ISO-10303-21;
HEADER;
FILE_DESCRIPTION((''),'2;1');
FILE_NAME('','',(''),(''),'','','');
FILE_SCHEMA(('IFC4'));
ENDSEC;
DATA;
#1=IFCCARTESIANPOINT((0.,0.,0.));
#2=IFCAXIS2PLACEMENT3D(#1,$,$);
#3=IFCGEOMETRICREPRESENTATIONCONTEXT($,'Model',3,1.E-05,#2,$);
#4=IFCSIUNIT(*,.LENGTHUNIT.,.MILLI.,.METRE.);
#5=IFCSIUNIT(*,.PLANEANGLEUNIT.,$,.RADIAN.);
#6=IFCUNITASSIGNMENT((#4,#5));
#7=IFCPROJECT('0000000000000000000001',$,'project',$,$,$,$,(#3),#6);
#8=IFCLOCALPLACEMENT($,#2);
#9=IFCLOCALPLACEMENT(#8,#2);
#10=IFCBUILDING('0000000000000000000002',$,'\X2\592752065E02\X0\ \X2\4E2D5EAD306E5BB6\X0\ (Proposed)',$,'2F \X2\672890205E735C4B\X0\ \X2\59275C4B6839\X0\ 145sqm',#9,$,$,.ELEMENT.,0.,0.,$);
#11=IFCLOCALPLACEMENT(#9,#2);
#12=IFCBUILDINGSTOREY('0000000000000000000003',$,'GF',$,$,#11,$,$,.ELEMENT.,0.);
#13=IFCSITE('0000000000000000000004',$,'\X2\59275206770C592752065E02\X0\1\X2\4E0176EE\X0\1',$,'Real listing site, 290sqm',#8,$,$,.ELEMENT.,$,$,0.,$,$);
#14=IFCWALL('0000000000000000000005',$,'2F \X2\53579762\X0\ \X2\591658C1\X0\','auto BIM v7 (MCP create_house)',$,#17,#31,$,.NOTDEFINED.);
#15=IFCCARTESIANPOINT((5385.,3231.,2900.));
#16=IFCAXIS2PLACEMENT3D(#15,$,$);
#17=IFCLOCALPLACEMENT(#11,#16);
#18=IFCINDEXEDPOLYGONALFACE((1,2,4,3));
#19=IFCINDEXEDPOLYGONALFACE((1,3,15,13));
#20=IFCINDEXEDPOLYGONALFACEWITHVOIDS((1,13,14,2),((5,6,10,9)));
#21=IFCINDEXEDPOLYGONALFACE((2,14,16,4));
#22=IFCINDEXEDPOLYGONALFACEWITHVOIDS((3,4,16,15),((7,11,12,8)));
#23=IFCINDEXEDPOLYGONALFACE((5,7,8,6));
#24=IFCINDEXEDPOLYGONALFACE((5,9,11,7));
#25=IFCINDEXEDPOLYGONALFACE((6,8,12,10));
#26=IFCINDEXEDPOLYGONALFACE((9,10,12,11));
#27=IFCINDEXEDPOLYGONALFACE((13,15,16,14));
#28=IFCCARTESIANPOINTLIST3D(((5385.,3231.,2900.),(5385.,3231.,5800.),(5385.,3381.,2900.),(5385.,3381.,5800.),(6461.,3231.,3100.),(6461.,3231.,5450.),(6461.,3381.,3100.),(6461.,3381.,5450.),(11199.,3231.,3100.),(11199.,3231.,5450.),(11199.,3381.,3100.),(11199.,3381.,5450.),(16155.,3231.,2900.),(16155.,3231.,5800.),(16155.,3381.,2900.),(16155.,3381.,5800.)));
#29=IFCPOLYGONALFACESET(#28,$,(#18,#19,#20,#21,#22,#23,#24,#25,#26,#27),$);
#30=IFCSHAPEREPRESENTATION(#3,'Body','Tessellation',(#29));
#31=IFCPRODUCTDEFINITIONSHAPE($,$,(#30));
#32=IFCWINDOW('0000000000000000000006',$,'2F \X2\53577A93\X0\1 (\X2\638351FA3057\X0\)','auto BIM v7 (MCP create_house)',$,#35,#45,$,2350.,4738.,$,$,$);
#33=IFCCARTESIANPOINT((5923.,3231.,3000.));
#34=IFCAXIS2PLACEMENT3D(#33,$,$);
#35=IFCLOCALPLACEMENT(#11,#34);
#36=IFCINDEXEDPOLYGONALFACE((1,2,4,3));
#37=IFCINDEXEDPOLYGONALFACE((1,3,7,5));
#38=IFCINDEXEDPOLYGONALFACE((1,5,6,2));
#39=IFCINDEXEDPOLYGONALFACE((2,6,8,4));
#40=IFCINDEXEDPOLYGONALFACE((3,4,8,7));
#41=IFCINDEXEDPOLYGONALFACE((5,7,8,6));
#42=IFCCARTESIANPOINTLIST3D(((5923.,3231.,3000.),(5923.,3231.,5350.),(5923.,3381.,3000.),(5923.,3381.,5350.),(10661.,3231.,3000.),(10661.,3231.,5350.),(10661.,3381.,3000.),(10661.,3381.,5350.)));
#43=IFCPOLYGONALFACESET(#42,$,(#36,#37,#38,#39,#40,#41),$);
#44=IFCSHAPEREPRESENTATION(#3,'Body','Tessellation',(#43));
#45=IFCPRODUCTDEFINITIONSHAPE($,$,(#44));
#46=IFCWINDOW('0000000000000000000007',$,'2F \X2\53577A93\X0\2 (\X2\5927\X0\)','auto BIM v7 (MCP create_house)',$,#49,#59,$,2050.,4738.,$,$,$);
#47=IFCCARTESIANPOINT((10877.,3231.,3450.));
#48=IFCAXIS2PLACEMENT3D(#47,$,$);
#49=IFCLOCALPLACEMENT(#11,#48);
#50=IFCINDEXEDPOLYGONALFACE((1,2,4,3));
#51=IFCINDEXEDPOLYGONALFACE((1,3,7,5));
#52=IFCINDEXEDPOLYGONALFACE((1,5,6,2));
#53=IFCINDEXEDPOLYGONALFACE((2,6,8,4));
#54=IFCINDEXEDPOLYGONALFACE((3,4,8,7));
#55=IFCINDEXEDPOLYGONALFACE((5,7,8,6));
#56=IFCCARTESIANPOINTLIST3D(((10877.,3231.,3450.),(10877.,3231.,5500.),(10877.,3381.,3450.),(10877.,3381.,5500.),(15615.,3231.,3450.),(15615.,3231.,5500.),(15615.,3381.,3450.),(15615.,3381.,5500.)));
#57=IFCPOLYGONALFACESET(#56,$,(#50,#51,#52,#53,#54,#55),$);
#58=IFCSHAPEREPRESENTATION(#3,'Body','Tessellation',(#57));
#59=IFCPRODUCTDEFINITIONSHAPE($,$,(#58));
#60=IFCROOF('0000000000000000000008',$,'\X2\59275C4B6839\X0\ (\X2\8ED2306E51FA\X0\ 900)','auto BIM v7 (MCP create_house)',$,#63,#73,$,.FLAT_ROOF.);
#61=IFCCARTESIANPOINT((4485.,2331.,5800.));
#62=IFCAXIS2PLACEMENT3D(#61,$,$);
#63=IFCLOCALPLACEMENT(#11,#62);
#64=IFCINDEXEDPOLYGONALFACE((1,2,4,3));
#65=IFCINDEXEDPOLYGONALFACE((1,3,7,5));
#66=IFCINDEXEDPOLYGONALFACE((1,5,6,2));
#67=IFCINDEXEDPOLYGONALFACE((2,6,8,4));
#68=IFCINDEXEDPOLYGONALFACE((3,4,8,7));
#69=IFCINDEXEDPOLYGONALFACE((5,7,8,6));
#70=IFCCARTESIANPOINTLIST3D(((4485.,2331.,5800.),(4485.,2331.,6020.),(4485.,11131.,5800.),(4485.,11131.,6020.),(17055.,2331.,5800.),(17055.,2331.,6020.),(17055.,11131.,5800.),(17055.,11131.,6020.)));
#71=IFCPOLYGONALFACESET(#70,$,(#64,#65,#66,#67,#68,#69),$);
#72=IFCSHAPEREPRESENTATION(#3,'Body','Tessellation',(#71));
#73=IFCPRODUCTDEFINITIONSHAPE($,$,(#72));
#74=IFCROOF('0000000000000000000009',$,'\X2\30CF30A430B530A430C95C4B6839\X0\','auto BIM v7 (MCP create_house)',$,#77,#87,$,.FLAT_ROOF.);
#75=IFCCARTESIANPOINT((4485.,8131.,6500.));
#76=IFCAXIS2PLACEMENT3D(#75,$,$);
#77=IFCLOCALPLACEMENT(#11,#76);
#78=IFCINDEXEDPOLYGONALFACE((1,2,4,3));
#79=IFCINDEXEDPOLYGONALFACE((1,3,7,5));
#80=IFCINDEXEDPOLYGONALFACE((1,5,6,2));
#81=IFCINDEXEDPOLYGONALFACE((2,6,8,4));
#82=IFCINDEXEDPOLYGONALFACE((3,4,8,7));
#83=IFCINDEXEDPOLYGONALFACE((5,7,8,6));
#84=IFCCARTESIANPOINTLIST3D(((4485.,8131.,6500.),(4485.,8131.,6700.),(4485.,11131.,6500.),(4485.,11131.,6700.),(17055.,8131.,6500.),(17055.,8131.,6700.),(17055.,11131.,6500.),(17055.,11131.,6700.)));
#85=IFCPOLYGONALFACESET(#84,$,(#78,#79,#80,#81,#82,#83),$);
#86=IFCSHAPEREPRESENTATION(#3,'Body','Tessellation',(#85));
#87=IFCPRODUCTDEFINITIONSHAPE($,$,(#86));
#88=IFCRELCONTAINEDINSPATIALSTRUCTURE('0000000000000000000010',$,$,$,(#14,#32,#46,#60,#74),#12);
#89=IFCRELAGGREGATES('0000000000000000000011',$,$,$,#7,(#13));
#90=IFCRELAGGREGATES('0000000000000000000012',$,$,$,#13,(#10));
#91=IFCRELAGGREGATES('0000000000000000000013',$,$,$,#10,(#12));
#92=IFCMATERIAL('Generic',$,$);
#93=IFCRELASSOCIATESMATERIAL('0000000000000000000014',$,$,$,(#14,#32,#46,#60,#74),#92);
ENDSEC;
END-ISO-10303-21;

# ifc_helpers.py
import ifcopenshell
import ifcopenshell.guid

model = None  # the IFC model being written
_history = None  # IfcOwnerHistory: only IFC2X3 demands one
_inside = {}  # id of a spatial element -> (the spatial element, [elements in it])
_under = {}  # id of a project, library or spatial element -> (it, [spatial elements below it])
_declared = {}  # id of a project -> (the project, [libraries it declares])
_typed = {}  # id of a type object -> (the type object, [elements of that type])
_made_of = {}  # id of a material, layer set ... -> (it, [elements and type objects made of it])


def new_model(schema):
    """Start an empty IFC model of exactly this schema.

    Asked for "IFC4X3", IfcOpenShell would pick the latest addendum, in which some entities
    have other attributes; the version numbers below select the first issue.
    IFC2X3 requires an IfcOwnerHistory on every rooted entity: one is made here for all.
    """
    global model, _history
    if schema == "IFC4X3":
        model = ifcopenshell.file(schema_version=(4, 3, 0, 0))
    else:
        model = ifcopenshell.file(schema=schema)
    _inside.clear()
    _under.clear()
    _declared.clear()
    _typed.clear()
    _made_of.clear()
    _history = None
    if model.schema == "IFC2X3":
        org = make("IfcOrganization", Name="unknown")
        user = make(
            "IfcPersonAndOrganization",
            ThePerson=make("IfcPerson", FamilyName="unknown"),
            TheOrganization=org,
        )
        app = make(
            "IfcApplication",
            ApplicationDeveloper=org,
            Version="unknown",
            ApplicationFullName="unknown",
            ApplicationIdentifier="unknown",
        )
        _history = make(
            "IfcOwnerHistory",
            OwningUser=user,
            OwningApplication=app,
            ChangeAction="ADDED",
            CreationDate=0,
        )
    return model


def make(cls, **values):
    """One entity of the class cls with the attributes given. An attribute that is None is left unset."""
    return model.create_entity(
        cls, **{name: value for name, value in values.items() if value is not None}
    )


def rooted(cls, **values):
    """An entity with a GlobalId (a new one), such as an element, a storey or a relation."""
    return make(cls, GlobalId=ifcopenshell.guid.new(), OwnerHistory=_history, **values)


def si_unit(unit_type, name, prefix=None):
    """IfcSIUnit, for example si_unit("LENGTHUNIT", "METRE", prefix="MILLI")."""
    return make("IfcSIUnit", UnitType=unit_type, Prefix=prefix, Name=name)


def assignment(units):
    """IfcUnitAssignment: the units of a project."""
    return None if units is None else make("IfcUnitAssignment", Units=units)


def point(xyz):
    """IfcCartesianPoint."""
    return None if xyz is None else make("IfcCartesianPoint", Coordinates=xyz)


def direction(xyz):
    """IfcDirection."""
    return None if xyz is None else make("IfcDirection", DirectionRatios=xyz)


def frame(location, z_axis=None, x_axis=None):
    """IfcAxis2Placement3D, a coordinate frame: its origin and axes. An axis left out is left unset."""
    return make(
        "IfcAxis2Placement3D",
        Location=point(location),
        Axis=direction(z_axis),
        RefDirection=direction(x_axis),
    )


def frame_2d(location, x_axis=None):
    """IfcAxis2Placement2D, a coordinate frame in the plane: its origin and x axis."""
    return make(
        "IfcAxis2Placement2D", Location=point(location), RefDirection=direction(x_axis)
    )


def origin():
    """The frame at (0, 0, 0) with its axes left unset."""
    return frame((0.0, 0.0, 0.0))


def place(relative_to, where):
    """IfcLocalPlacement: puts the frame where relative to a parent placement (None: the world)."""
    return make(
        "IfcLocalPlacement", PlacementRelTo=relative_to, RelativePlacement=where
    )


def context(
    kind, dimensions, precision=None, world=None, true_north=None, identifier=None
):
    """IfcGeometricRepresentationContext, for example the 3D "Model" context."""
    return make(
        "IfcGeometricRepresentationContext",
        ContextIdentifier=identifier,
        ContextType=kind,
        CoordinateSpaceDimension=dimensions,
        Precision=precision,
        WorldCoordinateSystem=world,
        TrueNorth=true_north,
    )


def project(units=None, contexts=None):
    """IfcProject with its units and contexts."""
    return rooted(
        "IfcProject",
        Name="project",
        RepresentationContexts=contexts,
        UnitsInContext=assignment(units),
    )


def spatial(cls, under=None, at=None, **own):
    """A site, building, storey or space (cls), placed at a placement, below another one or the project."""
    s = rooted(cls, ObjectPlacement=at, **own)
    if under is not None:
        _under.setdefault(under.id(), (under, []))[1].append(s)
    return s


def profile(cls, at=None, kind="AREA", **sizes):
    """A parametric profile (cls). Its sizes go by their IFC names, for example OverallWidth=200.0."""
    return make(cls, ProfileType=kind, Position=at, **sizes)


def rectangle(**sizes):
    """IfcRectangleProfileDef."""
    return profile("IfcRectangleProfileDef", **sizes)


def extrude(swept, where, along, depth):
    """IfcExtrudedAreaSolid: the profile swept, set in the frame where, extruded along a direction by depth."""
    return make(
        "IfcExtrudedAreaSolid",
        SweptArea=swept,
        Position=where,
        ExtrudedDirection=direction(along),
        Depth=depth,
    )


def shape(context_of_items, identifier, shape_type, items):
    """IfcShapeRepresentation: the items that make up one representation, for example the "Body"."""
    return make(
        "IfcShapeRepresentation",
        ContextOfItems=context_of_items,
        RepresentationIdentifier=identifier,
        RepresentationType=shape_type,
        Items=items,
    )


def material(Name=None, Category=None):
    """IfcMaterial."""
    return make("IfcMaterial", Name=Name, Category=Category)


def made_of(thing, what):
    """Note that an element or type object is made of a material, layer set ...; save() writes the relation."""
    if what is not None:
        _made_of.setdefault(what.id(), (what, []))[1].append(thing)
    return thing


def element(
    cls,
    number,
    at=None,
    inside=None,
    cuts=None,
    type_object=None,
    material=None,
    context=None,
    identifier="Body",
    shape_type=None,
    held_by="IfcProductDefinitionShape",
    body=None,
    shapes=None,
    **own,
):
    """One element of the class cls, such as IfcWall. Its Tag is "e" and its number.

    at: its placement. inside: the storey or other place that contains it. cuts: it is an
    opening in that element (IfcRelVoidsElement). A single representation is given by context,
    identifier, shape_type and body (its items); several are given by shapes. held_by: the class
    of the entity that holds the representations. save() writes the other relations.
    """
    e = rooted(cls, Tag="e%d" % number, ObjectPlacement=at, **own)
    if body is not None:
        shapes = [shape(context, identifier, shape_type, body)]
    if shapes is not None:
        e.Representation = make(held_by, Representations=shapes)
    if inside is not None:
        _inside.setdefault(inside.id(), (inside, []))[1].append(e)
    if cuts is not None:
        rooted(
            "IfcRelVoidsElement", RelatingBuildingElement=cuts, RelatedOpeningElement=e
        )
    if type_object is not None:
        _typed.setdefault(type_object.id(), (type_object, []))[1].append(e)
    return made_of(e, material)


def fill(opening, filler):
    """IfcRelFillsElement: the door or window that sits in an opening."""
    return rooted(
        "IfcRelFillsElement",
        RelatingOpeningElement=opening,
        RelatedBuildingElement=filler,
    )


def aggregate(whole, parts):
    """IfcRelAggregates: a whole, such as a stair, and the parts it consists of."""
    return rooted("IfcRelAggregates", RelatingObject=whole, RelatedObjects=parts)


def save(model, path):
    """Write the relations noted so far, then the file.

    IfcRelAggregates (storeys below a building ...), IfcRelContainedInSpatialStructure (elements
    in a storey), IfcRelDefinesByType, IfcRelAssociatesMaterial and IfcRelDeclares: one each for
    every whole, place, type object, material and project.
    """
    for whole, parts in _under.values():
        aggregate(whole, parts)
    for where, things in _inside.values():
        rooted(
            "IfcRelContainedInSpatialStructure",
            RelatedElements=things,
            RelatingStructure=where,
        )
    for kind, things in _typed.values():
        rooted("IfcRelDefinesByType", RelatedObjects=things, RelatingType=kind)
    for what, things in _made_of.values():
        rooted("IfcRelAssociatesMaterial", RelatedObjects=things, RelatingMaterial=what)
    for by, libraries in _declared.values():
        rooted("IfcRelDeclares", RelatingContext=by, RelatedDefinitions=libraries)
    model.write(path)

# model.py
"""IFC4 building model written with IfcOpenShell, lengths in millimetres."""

from ifc_helpers import new_model, si_unit, frame, frame_2d, origin, place, context, project, spatial, rectangle, extrude, material, element, fill, save


model = new_model("IFC4")

# Units and contexts
model_context = context("Model", 3, precision=1e-05, world=origin())
ifc_project = project(units=[si_unit("LENGTHUNIT", "METRE", prefix="MILLI"), si_unit("PLANEANGLEUNIT", "RADIAN")], contexts=[model_context])

# Site, building, storey
site_placement = place(None, origin())
site = spatial("IfcSite", under=ifc_project, at=site_placement, Name="大分県大分市1丁目1", ObjectType="Real listing site, 290sqm", CompositionType="ELEMENT", RefElevation=0.0)
building_placement = place(site_placement, origin())
building = spatial("IfcBuilding", under=site, at=building_placement, Name="大分市 中庭の家 (Proposed)", ObjectType="2F 木造平屋 大屋根 145sqm", CompositionType="ELEMENT", ElevationOfRefHeight=0.0, ElevationOfTerrain=0.0)
storey_placement = place(building_placement, origin())
storey = spatial("IfcBuildingStorey", under=building, at=storey_placement, Name="GF", CompositionType="ELEMENT", Elevation=0.0)

# Shared definitions
ifc_material = material(Name="Generic")

# Wall, openings, windows
wall_1_placement = place(storey_placement, frame((5385.0, 3231.0, 2900.0)))
wall_1 = element("IfcWall", 1, at=wall_1_placement, inside=storey, material=ifc_material, Name="2F 南面 外壁", Description="auto BIM v7 (MCP create_house)", PredefinedType="NOTDEFINED", context=model_context, shape_type="SweptSolid", body=[
    extrude(rectangle(XDim=10770.0, YDim=150.0, at=frame_2d((5385.0, 75.0))), frame((5385.0, 3231.0, 2900.0)), (0.0, 0.0, 1.0), 2900.0),
])
opening_1_placement = place(storey_placement, frame((5923.0, 3231.0, 3000.0)))
opening_1 = element("IfcOpeningElement", 2, at=opening_1_placement, cuts=wall_1, PredefinedType="NOTDEFINED", context=model_context, shape_type="SweptSolid", body=[
    extrude(rectangle(XDim=4738.0, YDim=150.0, at=frame_2d((2369.0, 75.0))), frame((5923.0, 3231.0, 3000.0)), (0.0, 0.0, 1.0), 2350.0),
])
opening_2_placement = place(storey_placement, frame((10877.0, 3231.0, 3450.0)))
opening_2 = element("IfcOpeningElement", 3, at=opening_2_placement, cuts=wall_1, PredefinedType="NOTDEFINED", context=model_context, shape_type="SweptSolid", body=[
    extrude(rectangle(XDim=4738.0, YDim=150.0, at=frame_2d((2369.0, 75.0))), frame((10877.0, 3231.0, 3450.0)), (0.0, 0.0, 1.0), 2050.0),
])
window_1_placement = place(storey_placement, frame((5923.0, 3231.0, 3000.0)))
window_1 = element("IfcWindow", 4, at=window_1_placement, inside=storey, material=ifc_material, Name="2F 南窓1 (掃出し)", Description="auto BIM v7 (MCP create_house)", OverallHeight=2350.0, OverallWidth=4738.0, context=model_context, shape_type="SweptSolid", body=[
    extrude(rectangle(XDim=4738.0, YDim=150.0, at=frame_2d((2369.0, 75.0))), frame((5923.0, 3231.0, 3000.0)), (0.0, 0.0, 1.0), 2350.0),
])
fill(opening_1, window_1)
window_2_placement = place(storey_placement, frame((10877.0, 3231.0, 3450.0)))
window_2 = element("IfcWindow", 5, at=window_2_placement, inside=storey, material=ifc_material, Name="2F 南窓2 (大)", Description="auto BIM v7 (MCP create_house)", OverallHeight=2050.0, OverallWidth=4738.0, context=model_context, shape_type="SweptSolid", body=[
    extrude(rectangle(XDim=4738.0, YDim=150.0, at=frame_2d((2369.0, 75.0))), frame((10877.0, 3231.0, 3450.0)), (0.0, 0.0, 1.0), 2050.0),
])
fill(opening_2, window_2)

# Roofs
roof_1_placement = place(storey_placement, frame((4485.0, 2331.0, 5800.0)))
element("IfcRoof", 6, at=roof_1_placement, inside=storey, material=ifc_material, Name="大屋根 (軒の出 900)", Description="auto BIM v7 (MCP create_house)", PredefinedType="FLAT_ROOF", context=model_context, shape_type="SweptSolid", body=[
    extrude(rectangle(XDim=12570.0, YDim=8800.0, at=frame_2d((6285.0, 4400.0))), frame((4485.0, 2331.0, 5800.0)), (0.0, 0.0, 1.0), 220.0),
])
roof_2_placement = place(storey_placement, frame((4485.0, 8131.0, 6500.0)))
element("IfcRoof", 7, at=roof_2_placement, inside=storey, material=ifc_material, Name="ハイサイド屋根", Description="auto BIM v7 (MCP create_house)", PredefinedType="FLAT_ROOF", context=model_context, shape_type="SweptSolid", body=[
    extrude(rectangle(XDim=12570.0, YDim=3000.0, at=frame_2d((6285.0, 1500.0))), frame((4485.0, 8131.0, 6500.0)), (0.0, 0.0, 1.0), 200.0),
])

save(model, "model.ifc")
